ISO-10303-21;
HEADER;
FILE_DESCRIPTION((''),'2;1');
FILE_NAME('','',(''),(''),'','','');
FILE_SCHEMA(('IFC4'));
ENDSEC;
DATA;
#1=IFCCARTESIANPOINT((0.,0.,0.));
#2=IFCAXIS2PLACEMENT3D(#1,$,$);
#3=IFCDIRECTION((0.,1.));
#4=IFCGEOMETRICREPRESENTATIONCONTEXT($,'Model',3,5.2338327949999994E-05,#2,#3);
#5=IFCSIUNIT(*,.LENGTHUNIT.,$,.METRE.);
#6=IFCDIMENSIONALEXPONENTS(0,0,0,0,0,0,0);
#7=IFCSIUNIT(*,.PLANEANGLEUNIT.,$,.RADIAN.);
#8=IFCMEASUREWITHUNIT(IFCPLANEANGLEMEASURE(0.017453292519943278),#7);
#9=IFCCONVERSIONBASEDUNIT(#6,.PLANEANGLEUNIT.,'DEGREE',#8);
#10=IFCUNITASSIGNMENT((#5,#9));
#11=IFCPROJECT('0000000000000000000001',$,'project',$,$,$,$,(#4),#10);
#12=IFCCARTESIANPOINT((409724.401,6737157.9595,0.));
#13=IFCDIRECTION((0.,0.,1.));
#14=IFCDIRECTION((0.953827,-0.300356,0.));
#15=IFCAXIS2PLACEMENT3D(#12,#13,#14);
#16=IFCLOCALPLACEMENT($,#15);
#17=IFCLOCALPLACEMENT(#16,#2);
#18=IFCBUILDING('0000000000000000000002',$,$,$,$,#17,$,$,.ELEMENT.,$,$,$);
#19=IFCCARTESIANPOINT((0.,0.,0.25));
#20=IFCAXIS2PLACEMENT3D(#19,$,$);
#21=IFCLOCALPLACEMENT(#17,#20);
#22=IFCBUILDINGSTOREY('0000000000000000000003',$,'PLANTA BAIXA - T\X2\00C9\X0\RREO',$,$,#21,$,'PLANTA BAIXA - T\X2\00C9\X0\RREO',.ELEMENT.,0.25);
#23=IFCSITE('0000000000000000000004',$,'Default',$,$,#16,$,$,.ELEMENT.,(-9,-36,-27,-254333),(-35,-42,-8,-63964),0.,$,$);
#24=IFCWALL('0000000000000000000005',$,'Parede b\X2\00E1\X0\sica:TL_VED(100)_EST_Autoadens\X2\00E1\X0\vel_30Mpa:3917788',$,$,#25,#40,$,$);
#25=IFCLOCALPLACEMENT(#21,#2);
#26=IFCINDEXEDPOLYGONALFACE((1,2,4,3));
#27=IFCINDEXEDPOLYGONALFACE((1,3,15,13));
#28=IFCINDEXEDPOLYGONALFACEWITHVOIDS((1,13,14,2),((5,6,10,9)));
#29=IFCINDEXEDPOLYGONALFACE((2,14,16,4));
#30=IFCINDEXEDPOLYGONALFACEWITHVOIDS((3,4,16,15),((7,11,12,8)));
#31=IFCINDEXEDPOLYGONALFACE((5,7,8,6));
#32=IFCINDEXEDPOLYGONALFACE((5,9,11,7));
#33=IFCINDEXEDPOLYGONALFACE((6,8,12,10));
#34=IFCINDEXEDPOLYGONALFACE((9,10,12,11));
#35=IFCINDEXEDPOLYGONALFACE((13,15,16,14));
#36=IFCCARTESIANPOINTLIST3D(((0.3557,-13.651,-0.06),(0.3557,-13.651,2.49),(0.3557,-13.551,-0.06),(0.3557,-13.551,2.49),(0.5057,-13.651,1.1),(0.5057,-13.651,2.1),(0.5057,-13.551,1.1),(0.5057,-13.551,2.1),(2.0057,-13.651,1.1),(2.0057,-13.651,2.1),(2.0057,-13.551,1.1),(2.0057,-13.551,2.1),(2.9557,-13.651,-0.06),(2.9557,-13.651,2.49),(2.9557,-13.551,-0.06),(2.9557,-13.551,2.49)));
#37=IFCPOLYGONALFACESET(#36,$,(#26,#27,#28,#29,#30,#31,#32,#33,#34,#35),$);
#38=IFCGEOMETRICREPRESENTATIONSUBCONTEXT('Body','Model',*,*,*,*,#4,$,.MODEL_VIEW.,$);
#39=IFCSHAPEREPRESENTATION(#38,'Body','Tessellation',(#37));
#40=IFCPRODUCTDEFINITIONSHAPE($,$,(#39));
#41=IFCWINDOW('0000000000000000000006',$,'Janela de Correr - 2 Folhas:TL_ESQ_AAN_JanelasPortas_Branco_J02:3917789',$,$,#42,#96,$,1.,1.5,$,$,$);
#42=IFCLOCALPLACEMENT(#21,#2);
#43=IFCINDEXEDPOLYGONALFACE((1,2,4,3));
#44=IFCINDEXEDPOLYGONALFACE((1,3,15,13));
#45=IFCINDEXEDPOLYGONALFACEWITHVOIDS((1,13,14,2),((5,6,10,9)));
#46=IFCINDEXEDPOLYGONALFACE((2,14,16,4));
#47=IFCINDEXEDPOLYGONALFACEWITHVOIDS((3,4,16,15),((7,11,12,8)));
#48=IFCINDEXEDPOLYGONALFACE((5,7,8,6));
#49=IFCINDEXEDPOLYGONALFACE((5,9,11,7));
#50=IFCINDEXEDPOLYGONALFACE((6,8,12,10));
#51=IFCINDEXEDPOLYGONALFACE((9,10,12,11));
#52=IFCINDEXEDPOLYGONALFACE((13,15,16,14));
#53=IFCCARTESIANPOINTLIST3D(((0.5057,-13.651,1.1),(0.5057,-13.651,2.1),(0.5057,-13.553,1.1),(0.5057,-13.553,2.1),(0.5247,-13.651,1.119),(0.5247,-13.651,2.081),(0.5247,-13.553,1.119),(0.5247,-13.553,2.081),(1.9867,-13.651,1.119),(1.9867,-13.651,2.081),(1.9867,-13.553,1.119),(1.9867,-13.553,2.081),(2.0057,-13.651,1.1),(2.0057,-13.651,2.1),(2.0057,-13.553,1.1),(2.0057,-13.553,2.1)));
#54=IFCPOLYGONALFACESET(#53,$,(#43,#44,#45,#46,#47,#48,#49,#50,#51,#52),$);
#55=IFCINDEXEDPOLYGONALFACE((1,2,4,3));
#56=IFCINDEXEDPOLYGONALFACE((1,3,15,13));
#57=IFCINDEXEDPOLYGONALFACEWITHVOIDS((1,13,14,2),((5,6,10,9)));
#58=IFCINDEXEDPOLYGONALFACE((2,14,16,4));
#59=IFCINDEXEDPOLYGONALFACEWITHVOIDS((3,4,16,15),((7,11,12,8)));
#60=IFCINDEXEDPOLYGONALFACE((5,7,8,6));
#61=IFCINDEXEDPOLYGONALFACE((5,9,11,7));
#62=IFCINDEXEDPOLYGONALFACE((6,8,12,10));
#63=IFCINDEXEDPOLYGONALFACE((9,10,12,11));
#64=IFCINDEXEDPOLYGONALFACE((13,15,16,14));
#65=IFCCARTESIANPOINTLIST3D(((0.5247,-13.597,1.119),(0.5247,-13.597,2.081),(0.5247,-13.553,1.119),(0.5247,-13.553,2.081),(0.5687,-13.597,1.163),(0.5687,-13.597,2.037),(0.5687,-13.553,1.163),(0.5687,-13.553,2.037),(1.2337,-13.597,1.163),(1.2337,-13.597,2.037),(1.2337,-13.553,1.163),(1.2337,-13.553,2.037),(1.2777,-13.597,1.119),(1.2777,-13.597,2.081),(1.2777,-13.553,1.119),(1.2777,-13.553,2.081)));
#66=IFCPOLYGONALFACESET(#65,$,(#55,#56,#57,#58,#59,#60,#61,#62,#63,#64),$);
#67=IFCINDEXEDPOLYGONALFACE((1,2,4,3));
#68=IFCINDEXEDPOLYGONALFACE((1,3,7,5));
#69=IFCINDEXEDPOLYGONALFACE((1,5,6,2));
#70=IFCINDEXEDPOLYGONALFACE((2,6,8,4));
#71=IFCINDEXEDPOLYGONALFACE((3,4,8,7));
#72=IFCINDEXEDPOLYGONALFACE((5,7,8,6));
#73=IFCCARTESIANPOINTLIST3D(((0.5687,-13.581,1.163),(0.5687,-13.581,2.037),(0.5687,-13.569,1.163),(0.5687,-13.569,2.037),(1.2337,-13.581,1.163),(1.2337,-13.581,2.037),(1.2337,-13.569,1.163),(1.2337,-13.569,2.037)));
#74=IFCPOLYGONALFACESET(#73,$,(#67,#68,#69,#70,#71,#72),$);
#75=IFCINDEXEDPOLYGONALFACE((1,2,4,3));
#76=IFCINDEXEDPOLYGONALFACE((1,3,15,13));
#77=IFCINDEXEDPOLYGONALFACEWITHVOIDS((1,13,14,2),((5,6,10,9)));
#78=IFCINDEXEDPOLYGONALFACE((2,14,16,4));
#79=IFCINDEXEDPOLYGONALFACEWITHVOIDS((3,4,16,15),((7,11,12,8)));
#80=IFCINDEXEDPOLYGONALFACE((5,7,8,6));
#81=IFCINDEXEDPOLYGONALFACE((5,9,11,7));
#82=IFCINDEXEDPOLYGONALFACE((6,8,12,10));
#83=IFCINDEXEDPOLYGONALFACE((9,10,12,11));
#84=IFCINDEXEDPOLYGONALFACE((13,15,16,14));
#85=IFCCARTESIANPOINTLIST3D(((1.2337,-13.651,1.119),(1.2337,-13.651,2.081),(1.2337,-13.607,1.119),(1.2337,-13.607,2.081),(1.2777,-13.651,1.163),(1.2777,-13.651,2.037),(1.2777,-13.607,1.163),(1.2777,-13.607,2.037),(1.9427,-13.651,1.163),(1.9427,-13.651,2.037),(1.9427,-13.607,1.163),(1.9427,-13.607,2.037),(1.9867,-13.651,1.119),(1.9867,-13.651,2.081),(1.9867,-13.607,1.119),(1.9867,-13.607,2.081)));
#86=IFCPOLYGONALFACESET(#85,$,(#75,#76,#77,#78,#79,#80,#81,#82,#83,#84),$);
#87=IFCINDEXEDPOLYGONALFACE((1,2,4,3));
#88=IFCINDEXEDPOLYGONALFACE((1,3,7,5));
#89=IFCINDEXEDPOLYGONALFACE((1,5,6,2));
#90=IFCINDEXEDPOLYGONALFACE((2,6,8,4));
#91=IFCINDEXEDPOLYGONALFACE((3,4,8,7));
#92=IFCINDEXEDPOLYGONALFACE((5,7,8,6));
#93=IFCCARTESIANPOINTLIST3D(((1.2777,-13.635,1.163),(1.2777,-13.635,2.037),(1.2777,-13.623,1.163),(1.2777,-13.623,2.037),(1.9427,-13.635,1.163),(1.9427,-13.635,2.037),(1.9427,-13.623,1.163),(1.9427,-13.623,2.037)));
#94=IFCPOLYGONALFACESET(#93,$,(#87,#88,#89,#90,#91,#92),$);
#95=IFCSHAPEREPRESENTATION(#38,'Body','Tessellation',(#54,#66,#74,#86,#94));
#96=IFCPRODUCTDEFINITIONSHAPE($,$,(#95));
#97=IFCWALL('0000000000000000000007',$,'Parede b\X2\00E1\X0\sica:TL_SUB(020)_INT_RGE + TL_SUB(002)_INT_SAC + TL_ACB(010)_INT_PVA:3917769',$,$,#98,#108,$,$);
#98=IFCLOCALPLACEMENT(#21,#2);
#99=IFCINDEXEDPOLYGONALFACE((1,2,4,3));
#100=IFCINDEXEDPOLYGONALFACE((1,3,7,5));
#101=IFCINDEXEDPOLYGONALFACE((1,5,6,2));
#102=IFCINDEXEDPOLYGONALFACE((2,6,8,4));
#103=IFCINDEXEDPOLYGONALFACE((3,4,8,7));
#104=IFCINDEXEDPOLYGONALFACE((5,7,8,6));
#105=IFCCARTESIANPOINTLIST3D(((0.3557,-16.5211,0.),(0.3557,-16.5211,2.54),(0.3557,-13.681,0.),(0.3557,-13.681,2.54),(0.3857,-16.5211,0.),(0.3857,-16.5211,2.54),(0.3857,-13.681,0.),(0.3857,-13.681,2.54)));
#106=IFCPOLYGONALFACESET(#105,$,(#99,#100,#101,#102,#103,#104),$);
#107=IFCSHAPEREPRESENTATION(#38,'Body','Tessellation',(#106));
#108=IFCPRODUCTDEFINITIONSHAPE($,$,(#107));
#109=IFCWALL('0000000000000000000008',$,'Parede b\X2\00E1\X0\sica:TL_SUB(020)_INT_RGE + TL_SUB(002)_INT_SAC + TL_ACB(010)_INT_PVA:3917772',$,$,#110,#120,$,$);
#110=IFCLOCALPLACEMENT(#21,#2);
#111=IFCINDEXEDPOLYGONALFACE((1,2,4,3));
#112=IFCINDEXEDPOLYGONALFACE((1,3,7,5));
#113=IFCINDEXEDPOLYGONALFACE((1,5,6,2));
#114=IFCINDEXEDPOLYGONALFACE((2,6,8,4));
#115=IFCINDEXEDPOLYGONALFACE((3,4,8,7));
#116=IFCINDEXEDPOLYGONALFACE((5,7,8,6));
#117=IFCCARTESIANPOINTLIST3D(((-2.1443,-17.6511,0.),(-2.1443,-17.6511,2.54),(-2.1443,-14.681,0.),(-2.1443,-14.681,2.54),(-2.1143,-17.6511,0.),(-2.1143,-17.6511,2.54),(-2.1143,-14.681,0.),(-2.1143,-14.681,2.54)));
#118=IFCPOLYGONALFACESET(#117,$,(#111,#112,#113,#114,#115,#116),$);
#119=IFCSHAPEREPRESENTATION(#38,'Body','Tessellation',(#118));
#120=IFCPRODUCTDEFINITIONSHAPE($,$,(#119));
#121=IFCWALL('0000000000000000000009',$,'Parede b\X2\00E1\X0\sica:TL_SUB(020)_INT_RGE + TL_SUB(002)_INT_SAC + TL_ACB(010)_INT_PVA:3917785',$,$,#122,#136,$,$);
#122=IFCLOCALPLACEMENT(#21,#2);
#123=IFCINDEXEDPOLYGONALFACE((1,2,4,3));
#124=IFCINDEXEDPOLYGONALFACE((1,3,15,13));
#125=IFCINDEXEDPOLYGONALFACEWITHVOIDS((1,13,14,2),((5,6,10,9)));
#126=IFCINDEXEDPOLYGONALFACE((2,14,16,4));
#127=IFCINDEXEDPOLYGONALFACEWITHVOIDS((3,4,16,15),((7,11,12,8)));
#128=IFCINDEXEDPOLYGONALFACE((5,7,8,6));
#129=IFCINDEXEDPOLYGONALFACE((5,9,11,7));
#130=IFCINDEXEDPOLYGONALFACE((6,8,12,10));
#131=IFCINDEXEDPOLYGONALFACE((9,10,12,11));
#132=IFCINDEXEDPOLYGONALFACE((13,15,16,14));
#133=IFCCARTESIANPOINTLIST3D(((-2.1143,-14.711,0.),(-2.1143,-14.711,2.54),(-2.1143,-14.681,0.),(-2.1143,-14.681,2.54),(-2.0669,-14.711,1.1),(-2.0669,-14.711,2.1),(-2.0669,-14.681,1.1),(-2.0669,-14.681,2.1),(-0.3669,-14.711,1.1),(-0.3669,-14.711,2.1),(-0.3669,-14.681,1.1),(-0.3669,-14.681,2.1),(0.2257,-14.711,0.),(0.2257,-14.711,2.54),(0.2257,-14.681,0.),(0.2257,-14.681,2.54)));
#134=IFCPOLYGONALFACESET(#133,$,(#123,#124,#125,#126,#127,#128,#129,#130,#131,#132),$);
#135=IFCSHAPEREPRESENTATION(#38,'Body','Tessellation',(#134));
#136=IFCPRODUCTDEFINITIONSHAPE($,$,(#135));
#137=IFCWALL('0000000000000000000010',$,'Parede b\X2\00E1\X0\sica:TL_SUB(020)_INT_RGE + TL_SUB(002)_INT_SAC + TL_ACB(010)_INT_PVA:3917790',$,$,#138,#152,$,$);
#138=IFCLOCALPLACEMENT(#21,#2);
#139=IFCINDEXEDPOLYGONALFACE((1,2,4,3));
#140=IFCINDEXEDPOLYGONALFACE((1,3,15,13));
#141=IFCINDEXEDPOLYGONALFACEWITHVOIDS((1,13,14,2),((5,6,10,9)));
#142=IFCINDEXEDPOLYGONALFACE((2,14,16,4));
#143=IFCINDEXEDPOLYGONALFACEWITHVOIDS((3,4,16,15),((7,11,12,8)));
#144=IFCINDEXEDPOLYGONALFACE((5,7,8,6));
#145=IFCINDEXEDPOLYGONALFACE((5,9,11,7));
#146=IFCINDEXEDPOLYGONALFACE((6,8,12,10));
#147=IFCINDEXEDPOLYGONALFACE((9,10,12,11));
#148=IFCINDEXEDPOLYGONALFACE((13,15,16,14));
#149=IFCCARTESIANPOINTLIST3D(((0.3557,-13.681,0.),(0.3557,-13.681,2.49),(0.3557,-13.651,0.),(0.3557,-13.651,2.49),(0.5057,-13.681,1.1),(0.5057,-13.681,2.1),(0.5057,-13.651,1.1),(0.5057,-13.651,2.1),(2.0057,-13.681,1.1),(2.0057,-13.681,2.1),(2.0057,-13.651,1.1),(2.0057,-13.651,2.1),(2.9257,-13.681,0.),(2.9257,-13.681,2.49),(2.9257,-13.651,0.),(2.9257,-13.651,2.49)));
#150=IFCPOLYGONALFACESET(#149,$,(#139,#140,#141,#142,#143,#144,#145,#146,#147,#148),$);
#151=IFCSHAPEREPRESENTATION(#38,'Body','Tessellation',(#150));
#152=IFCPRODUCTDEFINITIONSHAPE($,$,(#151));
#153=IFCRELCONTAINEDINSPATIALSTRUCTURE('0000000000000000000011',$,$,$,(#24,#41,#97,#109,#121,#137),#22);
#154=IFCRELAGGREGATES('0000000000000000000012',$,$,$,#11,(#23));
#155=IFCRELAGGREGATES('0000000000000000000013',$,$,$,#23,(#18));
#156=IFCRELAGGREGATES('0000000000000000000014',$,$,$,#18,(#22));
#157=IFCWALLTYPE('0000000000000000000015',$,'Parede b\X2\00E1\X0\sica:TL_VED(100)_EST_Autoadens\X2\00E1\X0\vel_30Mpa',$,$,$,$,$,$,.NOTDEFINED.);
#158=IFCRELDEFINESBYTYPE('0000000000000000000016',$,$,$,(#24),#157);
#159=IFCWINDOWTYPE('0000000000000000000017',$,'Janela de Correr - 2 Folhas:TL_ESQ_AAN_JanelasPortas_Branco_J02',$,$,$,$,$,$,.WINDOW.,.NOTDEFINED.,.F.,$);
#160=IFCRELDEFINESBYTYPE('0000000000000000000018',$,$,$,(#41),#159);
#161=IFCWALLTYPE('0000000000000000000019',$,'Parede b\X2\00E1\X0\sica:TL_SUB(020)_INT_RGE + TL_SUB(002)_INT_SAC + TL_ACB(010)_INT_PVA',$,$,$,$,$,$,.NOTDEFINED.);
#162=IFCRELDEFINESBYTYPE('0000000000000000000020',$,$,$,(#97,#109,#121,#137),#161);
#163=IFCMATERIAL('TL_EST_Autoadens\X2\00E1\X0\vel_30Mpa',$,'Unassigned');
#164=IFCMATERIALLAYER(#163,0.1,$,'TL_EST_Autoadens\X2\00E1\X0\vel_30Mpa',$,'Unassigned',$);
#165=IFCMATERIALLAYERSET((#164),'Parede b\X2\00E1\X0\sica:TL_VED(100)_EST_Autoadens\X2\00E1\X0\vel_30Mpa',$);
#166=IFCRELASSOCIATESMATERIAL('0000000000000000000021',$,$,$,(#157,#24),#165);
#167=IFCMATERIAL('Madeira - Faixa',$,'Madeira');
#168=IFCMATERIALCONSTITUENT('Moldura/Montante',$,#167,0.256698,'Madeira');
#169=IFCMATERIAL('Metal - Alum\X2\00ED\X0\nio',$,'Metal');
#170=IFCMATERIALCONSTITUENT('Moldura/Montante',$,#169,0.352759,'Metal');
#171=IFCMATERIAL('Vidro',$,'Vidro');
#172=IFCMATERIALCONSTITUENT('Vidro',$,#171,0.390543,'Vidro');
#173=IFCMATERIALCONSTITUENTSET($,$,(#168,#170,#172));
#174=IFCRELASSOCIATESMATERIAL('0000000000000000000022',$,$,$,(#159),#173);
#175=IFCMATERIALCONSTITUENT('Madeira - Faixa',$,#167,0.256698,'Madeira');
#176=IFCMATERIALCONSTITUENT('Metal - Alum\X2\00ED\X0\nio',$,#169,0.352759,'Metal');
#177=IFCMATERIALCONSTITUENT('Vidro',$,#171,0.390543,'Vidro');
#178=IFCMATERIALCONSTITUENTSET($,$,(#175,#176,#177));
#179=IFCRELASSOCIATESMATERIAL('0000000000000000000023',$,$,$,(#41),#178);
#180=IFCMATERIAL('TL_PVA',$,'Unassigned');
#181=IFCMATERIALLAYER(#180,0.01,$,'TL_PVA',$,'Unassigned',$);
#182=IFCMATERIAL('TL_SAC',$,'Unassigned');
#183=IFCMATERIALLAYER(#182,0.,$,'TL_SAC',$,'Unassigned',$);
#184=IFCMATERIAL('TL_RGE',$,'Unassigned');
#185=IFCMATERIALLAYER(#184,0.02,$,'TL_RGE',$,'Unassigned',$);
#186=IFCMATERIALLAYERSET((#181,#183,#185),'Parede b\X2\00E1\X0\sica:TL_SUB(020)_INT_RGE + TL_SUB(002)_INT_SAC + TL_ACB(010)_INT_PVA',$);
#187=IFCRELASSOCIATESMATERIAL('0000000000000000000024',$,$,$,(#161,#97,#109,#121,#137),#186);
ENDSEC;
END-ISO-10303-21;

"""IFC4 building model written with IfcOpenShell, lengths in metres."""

from ifc_helpers import new_model, entity, si_unit, converted_unit, direction, frame, frame_2d, origin, origin_2d_with_axis, place, context, subcontext, project, spatial, polyline, rectangle, outline, extrude, source, transform, mapped, material, layer, layer_set, layer_usage, constituent, constituent_set, type_object, type_shapes, element, fill, save


model = new_model("IFC4")

# Units and contexts
model_context = context("Model", 3, precision=5.2338327949999994e-05, world=origin(), true_north=direction((0.0, 1.0)))
body_context = subcontext(model_context, "Body", "Model", "MODEL_VIEW")
ifc_project = project(units=[si_unit("LENGTHUNIT", "METRE"), converted_unit("PLANEANGLEUNIT", "DEGREE", entity("IfcPlaneAngleMeasure", 0.017453292519943278), si_unit("PLANEANGLEUNIT", "RADIAN"), dimensions=[0, 0, 0, 0, 0, 0, 0])], contexts=[model_context])

# Site, building, storey
site_placement = place(None, frame((409724.401, 6737157.9595, 0.0), z_axis=(0.0, 0.0, 1.0), x_axis=(0.953827, -0.300356, 0.0)))
site = spatial("IfcSite", under=ifc_project, at=site_placement, Name="Default", CompositionType="ELEMENT", RefLatitude=(-9, -36, -27, -254333), RefLongitude=(-35, -42, -8, -63964), RefElevation=0.0)
building_placement = place(site_placement, origin())
building = spatial("IfcBuilding", under=site, at=building_placement, CompositionType="ELEMENT")
storey_placement = place(building_placement, frame((0.0, 0.0, 0.25)))
storey = spatial("IfcBuildingStorey", under=building, at=storey_placement, Name="PLANTA BAIXA - TÉRREO", LongName="PLANTA BAIXA - TÉRREO", CompositionType="ELEMENT", Elevation=0.25)

# Shared definitions
ifc_material_1 = material(Name="TL_EST_Autoadensável_30Mpa", Category="Unassigned")
ifc_layer_1 = layer(ifc_material_1, 0.1, Name="TL_EST_Autoadensável_30Mpa", Category="Unassigned")
ifc_layer_set_1 = layer_set([ifc_layer_1], Name="Parede básica:TL_VED(100)_EST_Autoadensável_30Mpa")
wall_type_1 = type_object("IfcWallType", Name="Parede básica:TL_VED(100)_EST_Autoadensável_30Mpa", PredefinedType="NOTDEFINED", material=ifc_layer_set_1)

# Wall, opening, window
ifc_material_2 = material(Name="Madeira - Faixa", Category="Madeira")
ifc_material_3 = material(Name="Metal - Alumínio", Category="Metal")
ifc_material_4 = material(Name="Vidro", Category="Vidro")
ifc_layer_usage_1 = layer_usage(ifc_layer_set_1, "AXIS2", "NEGATIVE", 0.05)
wall_1_placement = place(storey_placement, frame((0.3557, -13.601, -0.06)))
wall_1 = element("IfcWall", 1, at=wall_1_placement, inside=storey, type_object=wall_type_1, material=ifc_layer_usage_1, Name="Parede básica:TL_VED(100)_EST_Autoadensável_30Mpa:3917788", context=body_context, shape_type="SweptSolid", body=[
    extrude(rectangle(XDim=2.6, YDim=0.1, at=frame_2d((1.3, 0.0), x_axis=(-1.0, 0.0))), origin(), (0.0, 0.0, 1.0), 2.55),
])
opening_1_placement = place(wall_1_placement, frame((0.15, -0.05, 1.16)))
opening_1 = element("IfcOpeningElement", 2, at=opening_1_placement, cuts=wall_1, PredefinedType="OPENING", context=body_context, shape_type="SweptSolid", body=[
    extrude(rectangle(XDim=1.0, YDim=1.5, at=frame_2d((0.5, 0.75), x_axis=(-1.0, 0.0))), frame((0.0, 0.0, 0.0), z_axis=(0.0, 1.0, 0.0), x_axis=(0.0, 0.0, 1.0)), (0.0, 0.0, 1.0), 0.1),
])
ifc_constituent_1 = constituent(ifc_material_2, Name="Madeira - Faixa", Category="Madeira", fraction=0.256698)
ifc_constituent_2 = constituent(ifc_material_3, Name="Metal - Alumínio", Category="Metal", fraction=0.352759)
ifc_constituent_3 = constituent(ifc_material_4, Name="Vidro", Category="Vidro", fraction=0.390543)
ifc_constituent_set_1 = constituent_set(constituents=[ifc_constituent_1, ifc_constituent_2, ifc_constituent_3])
ifc_constituent_4 = constituent(ifc_material_2, Name="Moldura/Montante", Category="Madeira", fraction=0.256698)
ifc_constituent_5 = constituent(ifc_material_3, Name="Moldura/Montante", Category="Metal", fraction=0.352759)
ifc_constituent_6 = constituent(ifc_material_4, Name="Vidro", Category="Vidro", fraction=0.390543)
ifc_constituent_set_2 = constituent_set(constituents=[ifc_constituent_4, ifc_constituent_5, ifc_constituent_6])
window_type_1 = type_object("IfcWindowType", Name="Janela de Correr - 2 Folhas:TL_ESQ_AAN_JanelasPortas_Branco_J02", ParameterTakesPrecedence=False, PartitioningType="NOTDEFINED", PredefinedType="WINDOW", material=ifc_constituent_set_2)
shared_shape_1 = source(origin(), body_context, "Body", "SweptSolid", [
    extrude(outline(polyline([(-0.75, -0.5), (0.75, -0.5), (0.75, 0.5), (-0.75, 0.5), (-0.75, -0.5)]), holes=[polyline([(-0.731, -0.481), (-0.731, 0.481), (0.731, 0.481), (0.731, -0.481), (-0.731, -0.481)])]), frame((0.75, 0.124, 0.5), z_axis=(0.0, -1.0, 0.0), x_axis=(-1.0, 0.0, 0.0)), (0.0, 0.0, 1.0), 0.098),
    extrude(outline(polyline([(-0.3765, -0.481), (0.3765, -0.481), (0.3765, 0.481), (-0.3765, 0.481), (-0.3765, -0.481)]), holes=[polyline([(-0.3325, -0.437), (-0.3325, 0.437), (0.3325, 0.437), (0.3325, -0.437), (-0.3325, -0.437)])]), frame((0.3955, 0.124, 0.5), z_axis=(0.0, -1.0, 0.0), x_axis=(-1.0, 0.0, 0.0)), (0.0, 0.0, 1.0), 0.044),
    extrude(rectangle(XDim=0.665, YDim=0.012, at=origin_2d_with_axis()), frame((0.3955, 0.102, 0.063), z_axis=(0.0, 0.0, 1.0), x_axis=(-1.0, 0.0, 0.0)), (0.0, 0.0, 1.0), 0.874),
    extrude(outline(polyline([(-0.481, -0.3765), (0.481, -0.3765), (0.481, 0.3765), (-0.481, 0.3765), (-0.481, -0.3765)]), holes=[polyline([(-0.437, -0.3325), (-0.437, 0.3325), (0.437, 0.3325), (0.437, -0.3325), (-0.437, -0.3325)])]), frame((1.1045, 0.07, 0.5), z_axis=(0.0, -1.0, 0.0), x_axis=(0.0, 0.0, -1.0)), (0.0, 0.0, 1.0), 0.044),
    extrude(rectangle(XDim=0.665, YDim=0.012, at=origin_2d_with_axis()), frame((1.1045, 0.048, 0.063), z_axis=(0.0, 0.0, 1.0), x_axis=(-1.0, 0.0, 0.0)), (0.0, 0.0, 1.0), 0.874),
])
type_shapes(window_type_1, [shared_shape_1])
window_1_placement = place(opening_1_placement, frame((0.0, -0.026, 0.0)))
window_1 = element("IfcWindow", 3, at=window_1_placement, inside=storey, type_object=window_type_1, material=ifc_constituent_set_1, Name="Janela de Correr - 2 Folhas:TL_ESQ_AAN_JanelasPortas_Branco_J02:3917789", OverallHeight=1.0, OverallWidth=1.5, context=body_context, shape_type="MappedRepresentation", body=[
    mapped(shared_shape_1, transform((0.0, 0.0, 0.0), scale=1.0)),
])
fill(opening_1, window_1)

# Walls
ifc_material_5 = material(Name="TL_PVA", Category="Unassigned")
ifc_layer_2 = layer(ifc_material_5, 0.01, Name="TL_PVA", Category="Unassigned")
ifc_material_6 = material(Name="TL_SAC", Category="Unassigned")
ifc_layer_3 = layer(ifc_material_6, 0.0, Name="TL_SAC", Category="Unassigned")
ifc_material_7 = material(Name="TL_RGE", Category="Unassigned")
ifc_layer_4 = layer(ifc_material_7, 0.02, Name="TL_RGE", Category="Unassigned")
ifc_layer_set_2 = layer_set([ifc_layer_2, ifc_layer_3, ifc_layer_4], Name="Parede básica:TL_SUB(020)_INT_RGE + TL_SUB(002)_INT_SAC + TL_ACB(010)_INT_PVA")
ifc_layer_usage_2 = layer_usage(ifc_layer_set_2, "AXIS2", "NEGATIVE", 0.015)
wall_type_2 = type_object("IfcWallType", Name="Parede básica:TL_SUB(020)_INT_RGE + TL_SUB(002)_INT_SAC + TL_ACB(010)_INT_PVA", PredefinedType="NOTDEFINED", material=ifc_layer_set_2)
wall_2_placement = place(storey_placement, frame((0.3707, -13.681, 0.0), z_axis=(0.0, 0.0, 1.0), x_axis=(0.0, -1.0, 0.0)))
element("IfcWall", 4, at=wall_2_placement, inside=storey, type_object=wall_type_2, material=ifc_layer_usage_2, Name="Parede básica:TL_SUB(020)_INT_RGE + TL_SUB(002)_INT_SAC + TL_ACB(010)_INT_PVA:3917769", context=body_context, shape_type="SweptSolid", body=[
    extrude(rectangle(XDim=2.8401, YDim=0.03, at=frame_2d((1.4201, 0.0), x_axis=(-1.0, 0.0))), origin(), (0.0, 0.0, 1.0), 2.54),
])
ifc_layer_usage_3 = layer_usage(ifc_layer_set_2, "AXIS2", "NEGATIVE", 0.015)
wall_3_placement = place(storey_placement, frame((-2.1293, -14.681, 0.0), z_axis=(0.0, 0.0, 1.0), x_axis=(0.0, -1.0, 0.0)))
element("IfcWall", 5, at=wall_3_placement, inside=storey, type_object=wall_type_2, material=ifc_layer_usage_3, Name="Parede básica:TL_SUB(020)_INT_RGE + TL_SUB(002)_INT_SAC + TL_ACB(010)_INT_PVA:3917772", context=body_context, shape_type="SweptSolid", body=[
    extrude(rectangle(XDim=2.9701, YDim=0.03, at=frame_2d((1.4851, 0.0), x_axis=(-1.0, 0.0))), origin(), (0.0, 0.0, 1.0), 2.54),
])

# Walls, openings
ifc_layer_usage_4 = layer_usage(ifc_layer_set_2, "AXIS2", "NEGATIVE", 0.015)
wall_4_placement = place(storey_placement, frame((0.2257, -14.696, 0.0), z_axis=(0.0, 0.0, 1.0), x_axis=(-1.0, 0.0, 0.0)))
wall_4 = element("IfcWall", 6, at=wall_4_placement, inside=storey, type_object=wall_type_2, material=ifc_layer_usage_4, Name="Parede básica:TL_SUB(020)_INT_RGE + TL_SUB(002)_INT_SAC + TL_ACB(010)_INT_PVA:3917785", context=body_context, shape_type="SweptSolid", body=[
    extrude(rectangle(XDim=2.34, YDim=0.03, at=frame_2d((1.17, 0.0), x_axis=(-1.0, 0.0))), origin(), (0.0, 0.0, 1.0), 2.54),
])
opening_2_placement = place(wall_4_placement, frame((0.2257, -14.696, 1.1)))
element("IfcOpeningElement", 7, at=opening_2_placement, cuts=wall_4, PredefinedType="OPENING", context=body_context, shape_type="SweptSolid", body=[
    extrude(rectangle(XDim=1.0, YDim=1.7, at=frame_2d((0.0, 0.0), x_axis=(0.0, 1.0))), frame((1.2169, 13.157, 0.5), z_axis=(0.0, 1.0, 0.0), x_axis=(1.0, 0.0, 0.0)), (0.0, 0.0, 1.0), 3.048),
])
ifc_layer_usage_5 = layer_usage(ifc_layer_set_2, "AXIS2", "NEGATIVE", 0.015)
wall_5_placement = place(storey_placement, frame((2.9257, -13.666, 0.0), z_axis=(0.0, 0.0, 1.0), x_axis=(-1.0, 0.0, 0.0)))
wall_5 = element("IfcWall", 8, at=wall_5_placement, inside=storey, type_object=wall_type_2, material=ifc_layer_usage_5, Name="Parede básica:TL_SUB(020)_INT_RGE + TL_SUB(002)_INT_SAC + TL_ACB(010)_INT_PVA:3917790", context=body_context, shape_type="SweptSolid", body=[
    extrude(rectangle(XDim=2.57, YDim=0.03, at=frame_2d((1.285, 0.0), x_axis=(-1.0, 0.0))), origin(), (0.0, 0.0, 1.0), 2.49),
])
opening_3_placement = place(wall_5_placement, frame((2.9257, -13.666, 1.1)))
element("IfcOpeningElement", 9, at=opening_3_placement, cuts=wall_5, PredefinedType="OPENING", context=body_context, shape_type="SweptSolid", body=[
    extrude(rectangle(XDim=1.0, YDim=1.5, at=frame_2d((0.0, 0.0), x_axis=(0.0, 1.0))), frame((-1.2557, 12.127, 0.5), z_axis=(0.0, 1.0, 0.0), x_axis=(1.0, 0.0, 0.0)), (0.0, 0.0, 1.0), 3.048),
])

save(model, "model.ifc")
